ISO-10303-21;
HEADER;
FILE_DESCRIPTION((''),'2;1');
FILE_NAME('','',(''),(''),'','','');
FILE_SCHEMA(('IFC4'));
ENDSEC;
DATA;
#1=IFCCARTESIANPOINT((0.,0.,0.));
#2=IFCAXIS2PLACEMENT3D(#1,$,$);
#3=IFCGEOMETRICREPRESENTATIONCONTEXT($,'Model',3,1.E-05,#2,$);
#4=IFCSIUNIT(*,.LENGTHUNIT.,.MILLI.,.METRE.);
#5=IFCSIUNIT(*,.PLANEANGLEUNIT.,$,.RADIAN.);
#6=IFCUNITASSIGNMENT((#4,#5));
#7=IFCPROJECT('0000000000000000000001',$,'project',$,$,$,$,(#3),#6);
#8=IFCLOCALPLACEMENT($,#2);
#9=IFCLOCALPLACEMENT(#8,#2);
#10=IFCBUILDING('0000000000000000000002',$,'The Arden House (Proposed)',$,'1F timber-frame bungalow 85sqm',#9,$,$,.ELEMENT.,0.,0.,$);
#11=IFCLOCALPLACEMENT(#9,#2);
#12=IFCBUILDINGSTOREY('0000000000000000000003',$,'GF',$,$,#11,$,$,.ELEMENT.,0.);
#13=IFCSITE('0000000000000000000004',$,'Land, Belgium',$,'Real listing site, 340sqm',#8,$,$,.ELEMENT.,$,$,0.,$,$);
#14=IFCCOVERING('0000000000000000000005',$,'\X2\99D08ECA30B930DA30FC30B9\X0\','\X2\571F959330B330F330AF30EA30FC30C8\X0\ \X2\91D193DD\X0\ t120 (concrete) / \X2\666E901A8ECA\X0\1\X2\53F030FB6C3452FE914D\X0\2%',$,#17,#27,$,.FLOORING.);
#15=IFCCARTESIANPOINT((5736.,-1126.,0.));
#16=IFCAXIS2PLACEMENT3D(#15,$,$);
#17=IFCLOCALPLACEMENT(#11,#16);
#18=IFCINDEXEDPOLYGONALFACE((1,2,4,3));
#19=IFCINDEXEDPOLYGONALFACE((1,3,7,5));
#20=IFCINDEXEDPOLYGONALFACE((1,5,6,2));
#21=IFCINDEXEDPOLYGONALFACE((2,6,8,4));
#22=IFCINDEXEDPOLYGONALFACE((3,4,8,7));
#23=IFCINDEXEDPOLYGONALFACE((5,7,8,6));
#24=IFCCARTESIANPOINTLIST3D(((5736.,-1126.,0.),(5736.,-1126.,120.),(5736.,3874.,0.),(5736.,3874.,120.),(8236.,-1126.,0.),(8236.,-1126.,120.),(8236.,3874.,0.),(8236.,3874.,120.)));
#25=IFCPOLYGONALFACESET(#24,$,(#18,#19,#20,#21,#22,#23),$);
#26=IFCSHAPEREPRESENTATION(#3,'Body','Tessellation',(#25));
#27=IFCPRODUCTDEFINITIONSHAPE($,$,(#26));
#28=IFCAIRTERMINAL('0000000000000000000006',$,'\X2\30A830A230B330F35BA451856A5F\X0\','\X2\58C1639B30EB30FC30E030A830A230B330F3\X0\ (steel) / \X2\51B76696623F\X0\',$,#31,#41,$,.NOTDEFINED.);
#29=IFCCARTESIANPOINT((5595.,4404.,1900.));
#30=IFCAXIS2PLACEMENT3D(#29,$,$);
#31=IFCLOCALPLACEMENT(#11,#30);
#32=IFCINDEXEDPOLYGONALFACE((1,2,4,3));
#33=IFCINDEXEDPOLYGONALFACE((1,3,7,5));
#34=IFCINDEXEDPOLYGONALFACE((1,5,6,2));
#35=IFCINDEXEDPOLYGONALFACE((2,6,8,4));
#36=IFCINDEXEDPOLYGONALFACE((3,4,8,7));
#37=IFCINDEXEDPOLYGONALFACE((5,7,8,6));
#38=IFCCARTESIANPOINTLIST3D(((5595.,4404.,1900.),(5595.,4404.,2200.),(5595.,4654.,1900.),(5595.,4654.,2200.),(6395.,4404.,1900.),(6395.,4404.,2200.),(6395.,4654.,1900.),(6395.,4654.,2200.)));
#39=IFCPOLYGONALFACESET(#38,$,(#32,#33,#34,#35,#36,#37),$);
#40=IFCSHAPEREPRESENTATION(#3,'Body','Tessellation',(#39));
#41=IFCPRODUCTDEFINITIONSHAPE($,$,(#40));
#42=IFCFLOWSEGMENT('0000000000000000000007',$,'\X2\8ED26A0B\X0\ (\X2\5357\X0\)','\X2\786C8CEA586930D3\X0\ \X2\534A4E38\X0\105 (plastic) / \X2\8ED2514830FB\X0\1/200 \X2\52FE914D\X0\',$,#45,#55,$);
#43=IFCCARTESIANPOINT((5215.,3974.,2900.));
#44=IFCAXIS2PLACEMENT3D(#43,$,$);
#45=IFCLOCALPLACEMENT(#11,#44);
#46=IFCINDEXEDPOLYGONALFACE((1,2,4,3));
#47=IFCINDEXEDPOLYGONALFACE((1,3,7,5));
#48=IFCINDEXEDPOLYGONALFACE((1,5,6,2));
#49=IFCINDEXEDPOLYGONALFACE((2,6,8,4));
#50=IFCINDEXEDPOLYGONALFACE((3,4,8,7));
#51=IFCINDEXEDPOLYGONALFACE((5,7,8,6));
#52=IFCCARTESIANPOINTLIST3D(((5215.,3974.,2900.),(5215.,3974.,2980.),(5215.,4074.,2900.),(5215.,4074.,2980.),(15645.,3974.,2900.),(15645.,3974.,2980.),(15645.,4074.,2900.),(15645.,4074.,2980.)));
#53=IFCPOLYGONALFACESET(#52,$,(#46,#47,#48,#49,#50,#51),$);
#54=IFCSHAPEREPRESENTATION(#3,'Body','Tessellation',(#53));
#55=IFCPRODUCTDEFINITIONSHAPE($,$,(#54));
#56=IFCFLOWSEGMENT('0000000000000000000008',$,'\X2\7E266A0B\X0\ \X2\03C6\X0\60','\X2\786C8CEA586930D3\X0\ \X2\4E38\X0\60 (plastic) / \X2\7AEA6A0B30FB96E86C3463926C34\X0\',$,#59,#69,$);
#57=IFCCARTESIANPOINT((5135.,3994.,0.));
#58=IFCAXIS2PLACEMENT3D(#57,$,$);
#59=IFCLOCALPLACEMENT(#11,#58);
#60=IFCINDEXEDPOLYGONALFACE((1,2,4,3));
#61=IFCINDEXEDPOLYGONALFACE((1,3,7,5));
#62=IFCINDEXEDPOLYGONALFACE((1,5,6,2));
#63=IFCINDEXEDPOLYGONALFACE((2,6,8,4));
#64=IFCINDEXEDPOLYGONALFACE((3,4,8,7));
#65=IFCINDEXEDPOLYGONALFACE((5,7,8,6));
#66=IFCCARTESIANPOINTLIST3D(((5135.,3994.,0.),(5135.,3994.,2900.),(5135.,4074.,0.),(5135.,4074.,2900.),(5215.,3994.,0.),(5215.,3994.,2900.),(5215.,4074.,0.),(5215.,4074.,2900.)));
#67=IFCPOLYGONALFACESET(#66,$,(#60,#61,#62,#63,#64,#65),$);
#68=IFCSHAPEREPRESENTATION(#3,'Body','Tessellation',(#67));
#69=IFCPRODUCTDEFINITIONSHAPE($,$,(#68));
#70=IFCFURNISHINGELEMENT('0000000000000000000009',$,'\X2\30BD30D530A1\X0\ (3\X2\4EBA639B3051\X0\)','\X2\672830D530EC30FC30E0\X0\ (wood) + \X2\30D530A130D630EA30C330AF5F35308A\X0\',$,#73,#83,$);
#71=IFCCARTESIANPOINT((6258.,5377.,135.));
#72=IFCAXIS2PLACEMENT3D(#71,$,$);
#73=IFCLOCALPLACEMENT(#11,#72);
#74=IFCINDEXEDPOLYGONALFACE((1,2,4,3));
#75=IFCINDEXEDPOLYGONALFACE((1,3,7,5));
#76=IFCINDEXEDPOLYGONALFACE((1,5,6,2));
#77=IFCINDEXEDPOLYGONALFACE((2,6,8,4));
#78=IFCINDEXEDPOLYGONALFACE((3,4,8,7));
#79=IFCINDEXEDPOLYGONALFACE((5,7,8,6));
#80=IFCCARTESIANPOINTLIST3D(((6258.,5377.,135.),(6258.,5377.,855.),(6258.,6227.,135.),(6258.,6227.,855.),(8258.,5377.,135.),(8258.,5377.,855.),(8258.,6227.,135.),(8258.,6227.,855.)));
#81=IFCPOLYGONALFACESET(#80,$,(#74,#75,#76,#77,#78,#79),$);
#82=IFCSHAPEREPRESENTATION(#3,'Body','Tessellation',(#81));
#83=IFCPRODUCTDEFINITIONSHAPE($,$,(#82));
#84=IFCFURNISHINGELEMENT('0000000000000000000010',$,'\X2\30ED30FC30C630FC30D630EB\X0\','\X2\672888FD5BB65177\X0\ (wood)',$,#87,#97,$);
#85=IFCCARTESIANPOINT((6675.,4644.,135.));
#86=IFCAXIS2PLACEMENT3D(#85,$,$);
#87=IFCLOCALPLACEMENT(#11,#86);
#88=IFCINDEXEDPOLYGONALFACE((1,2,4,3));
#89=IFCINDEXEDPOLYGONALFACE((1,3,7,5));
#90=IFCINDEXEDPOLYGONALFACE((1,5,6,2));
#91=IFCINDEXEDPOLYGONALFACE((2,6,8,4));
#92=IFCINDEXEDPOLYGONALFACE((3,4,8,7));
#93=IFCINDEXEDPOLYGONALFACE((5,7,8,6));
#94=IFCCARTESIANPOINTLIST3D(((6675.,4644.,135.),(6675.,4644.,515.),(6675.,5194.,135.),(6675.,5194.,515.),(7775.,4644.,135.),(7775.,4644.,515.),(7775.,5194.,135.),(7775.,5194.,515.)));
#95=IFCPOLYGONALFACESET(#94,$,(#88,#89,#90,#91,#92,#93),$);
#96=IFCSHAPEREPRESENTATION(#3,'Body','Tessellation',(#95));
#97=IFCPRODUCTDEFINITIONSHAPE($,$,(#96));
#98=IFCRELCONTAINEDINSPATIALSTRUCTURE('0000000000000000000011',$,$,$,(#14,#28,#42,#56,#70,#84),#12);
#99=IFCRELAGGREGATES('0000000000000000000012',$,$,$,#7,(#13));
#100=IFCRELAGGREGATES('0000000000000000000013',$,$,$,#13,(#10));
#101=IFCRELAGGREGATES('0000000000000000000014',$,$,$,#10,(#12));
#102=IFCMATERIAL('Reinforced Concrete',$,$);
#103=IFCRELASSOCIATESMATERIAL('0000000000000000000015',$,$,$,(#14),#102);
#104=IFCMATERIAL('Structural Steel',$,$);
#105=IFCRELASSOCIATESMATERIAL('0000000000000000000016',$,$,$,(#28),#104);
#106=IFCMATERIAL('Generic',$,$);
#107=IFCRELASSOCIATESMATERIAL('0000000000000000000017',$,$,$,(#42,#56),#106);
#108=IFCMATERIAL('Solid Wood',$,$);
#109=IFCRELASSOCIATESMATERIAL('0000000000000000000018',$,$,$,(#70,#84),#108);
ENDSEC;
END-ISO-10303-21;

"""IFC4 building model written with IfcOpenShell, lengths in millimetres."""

from ifc_helpers import new_model, si_unit, frame, frame_2d, origin, place, context, project, spatial, rectangle, extrude, material, element, save


model = new_model("IFC4")

# Units and contexts
model_context = context("Model", 3, precision=1e-05, world=origin())
ifc_project = project(units=[si_unit("LENGTHUNIT", "METRE", prefix="MILLI"), si_unit("PLANEANGLEUNIT", "RADIAN")], contexts=[model_context])

# Site, building, storey
site_placement = place(None, origin())
site = spatial("IfcSite", under=ifc_project, at=site_placement, Name="Land, Belgium", ObjectType="Real listing site, 340sqm", CompositionType="ELEMENT", RefElevation=0.0)
building_placement = place(site_placement, origin())
building = spatial("IfcBuilding", under=site, at=building_placement, Name="The Arden House (Proposed)", ObjectType="1F timber-frame bungalow 85sqm", CompositionType="ELEMENT", ElevationOfRefHeight=0.0, ElevationOfTerrain=0.0)
storey_placement = place(building_placement, origin())
storey = spatial("IfcBuildingStorey", under=building, at=storey_placement, Name="GF", CompositionType="ELEMENT", Elevation=0.0)

# Shared definitions
ifc_material_1 = material(Name="Solid Wood")

# Shared definitions
ifc_material_2 = material(Name="Reinforced Concrete")

# Shared definitions
ifc_material_3 = material(Name="Structural Steel")

# Covering
ifc_material_4 = material(Name="Generic")
covering_1_placement = place(storey_placement, frame((5736.0, -1126.0, 0.0)))
element("IfcCovering", 1, at=covering_1_placement, inside=storey, material=ifc_material_2, Name="駐車スペース", Description="土間コンクリート 金鏝 t120 (concrete) / 普通車1台・水勾配2%", PredefinedType="FLOORING", context=model_context, shape_type="SweptSolid", body=[
    extrude(rectangle(XDim=2500.0, YDim=5000.0, at=frame_2d((1250.0, 2500.0))), frame((5736.0, -1126.0, 0.0)), (0.0, 0.0, 1.0), 120.0),
])

# Air terminal
air_terminal_placement = place(storey_placement, frame((5595.0, 4404.0, 1900.0)))
element("IfcAirTerminal", 2, at=air_terminal_placement, inside=storey, material=ifc_material_3, Name="エアコン室内機", Description="壁掛ルームエアコン (steel) / 冷暖房", PredefinedType="NOTDEFINED", context=model_context, shape_type="SweptSolid", body=[
    extrude(rectangle(XDim=800.0, YDim=250.0, at=frame_2d((400.0, 125.0))), frame((5595.0, 4404.0, 1900.0)), (0.0, 0.0, 1.0), 300.0),
])

# Flow segments
flow_segment_1_placement = place(storey_placement, frame((5215.0, 3974.0, 2900.0)))
element("IfcFlowSegment", 3, at=flow_segment_1_placement, inside=storey, material=ifc_material_4, Name="軒樋 (南)", Description="硬質塩ビ 半丸105 (plastic) / 軒先・1/200 勾配", context=model_context, shape_type="SweptSolid", body=[
    extrude(rectangle(XDim=10430.0, YDim=100.0, at=frame_2d((5215.0, 50.0))), frame((5215.0, 3974.0, 2900.0)), (0.0, 0.0, 1.0), 80.0),
])
flow_segment_2_placement = place(storey_placement, frame((5135.0, 3994.0, 0.0)))
element("IfcFlowSegment", 4, at=flow_segment_2_placement, inside=storey, material=ifc_material_4, Name="縦樋 φ60", Description="硬質塩ビ 丸60 (plastic) / 竪樋・雨水排水", context=model_context, shape_type="SweptSolid", body=[
    extrude(rectangle(XDim=80.0, YDim=80.0, at=frame_2d((40.0, 40.0))), frame((5135.0, 3994.0, 0.0)), (0.0, 0.0, 1.0), 2900.0),
])

# Furnishing elements
furnishing_1_placement = place(storey_placement, frame((6258.0, 5377.0, 135.0)))
element("IfcFurnishingElement", 5, at=furnishing_1_placement, inside=storey, material=ifc_material_1, Name="ソファ (3人掛け)", Description="木フレーム (wood) + ファブリック張り", context=model_context, shape_type="SweptSolid", body=[
    extrude(rectangle(XDim=2000.0, YDim=850.0, at=frame_2d((1000.0, 425.0))), frame((6258.0, 5377.0, 135.0)), (0.0, 0.0, 1.0), 720.0),
])
furnishing_2_placement = place(storey_placement, frame((6675.0, 4644.0, 135.0)))
element("IfcFurnishingElement", 6, at=furnishing_2_placement, inside=storey, material=ifc_material_1, Name="ローテーブル", Description="木製家具 (wood)", context=model_context, shape_type="SweptSolid", body=[
    extrude(rectangle(XDim=1100.0, YDim=550.0, at=frame_2d((550.0, 275.0))), frame((6675.0, 4644.0, 135.0)), (0.0, 0.0, 1.0), 380.0),
])

save(model, "model.ifc")
